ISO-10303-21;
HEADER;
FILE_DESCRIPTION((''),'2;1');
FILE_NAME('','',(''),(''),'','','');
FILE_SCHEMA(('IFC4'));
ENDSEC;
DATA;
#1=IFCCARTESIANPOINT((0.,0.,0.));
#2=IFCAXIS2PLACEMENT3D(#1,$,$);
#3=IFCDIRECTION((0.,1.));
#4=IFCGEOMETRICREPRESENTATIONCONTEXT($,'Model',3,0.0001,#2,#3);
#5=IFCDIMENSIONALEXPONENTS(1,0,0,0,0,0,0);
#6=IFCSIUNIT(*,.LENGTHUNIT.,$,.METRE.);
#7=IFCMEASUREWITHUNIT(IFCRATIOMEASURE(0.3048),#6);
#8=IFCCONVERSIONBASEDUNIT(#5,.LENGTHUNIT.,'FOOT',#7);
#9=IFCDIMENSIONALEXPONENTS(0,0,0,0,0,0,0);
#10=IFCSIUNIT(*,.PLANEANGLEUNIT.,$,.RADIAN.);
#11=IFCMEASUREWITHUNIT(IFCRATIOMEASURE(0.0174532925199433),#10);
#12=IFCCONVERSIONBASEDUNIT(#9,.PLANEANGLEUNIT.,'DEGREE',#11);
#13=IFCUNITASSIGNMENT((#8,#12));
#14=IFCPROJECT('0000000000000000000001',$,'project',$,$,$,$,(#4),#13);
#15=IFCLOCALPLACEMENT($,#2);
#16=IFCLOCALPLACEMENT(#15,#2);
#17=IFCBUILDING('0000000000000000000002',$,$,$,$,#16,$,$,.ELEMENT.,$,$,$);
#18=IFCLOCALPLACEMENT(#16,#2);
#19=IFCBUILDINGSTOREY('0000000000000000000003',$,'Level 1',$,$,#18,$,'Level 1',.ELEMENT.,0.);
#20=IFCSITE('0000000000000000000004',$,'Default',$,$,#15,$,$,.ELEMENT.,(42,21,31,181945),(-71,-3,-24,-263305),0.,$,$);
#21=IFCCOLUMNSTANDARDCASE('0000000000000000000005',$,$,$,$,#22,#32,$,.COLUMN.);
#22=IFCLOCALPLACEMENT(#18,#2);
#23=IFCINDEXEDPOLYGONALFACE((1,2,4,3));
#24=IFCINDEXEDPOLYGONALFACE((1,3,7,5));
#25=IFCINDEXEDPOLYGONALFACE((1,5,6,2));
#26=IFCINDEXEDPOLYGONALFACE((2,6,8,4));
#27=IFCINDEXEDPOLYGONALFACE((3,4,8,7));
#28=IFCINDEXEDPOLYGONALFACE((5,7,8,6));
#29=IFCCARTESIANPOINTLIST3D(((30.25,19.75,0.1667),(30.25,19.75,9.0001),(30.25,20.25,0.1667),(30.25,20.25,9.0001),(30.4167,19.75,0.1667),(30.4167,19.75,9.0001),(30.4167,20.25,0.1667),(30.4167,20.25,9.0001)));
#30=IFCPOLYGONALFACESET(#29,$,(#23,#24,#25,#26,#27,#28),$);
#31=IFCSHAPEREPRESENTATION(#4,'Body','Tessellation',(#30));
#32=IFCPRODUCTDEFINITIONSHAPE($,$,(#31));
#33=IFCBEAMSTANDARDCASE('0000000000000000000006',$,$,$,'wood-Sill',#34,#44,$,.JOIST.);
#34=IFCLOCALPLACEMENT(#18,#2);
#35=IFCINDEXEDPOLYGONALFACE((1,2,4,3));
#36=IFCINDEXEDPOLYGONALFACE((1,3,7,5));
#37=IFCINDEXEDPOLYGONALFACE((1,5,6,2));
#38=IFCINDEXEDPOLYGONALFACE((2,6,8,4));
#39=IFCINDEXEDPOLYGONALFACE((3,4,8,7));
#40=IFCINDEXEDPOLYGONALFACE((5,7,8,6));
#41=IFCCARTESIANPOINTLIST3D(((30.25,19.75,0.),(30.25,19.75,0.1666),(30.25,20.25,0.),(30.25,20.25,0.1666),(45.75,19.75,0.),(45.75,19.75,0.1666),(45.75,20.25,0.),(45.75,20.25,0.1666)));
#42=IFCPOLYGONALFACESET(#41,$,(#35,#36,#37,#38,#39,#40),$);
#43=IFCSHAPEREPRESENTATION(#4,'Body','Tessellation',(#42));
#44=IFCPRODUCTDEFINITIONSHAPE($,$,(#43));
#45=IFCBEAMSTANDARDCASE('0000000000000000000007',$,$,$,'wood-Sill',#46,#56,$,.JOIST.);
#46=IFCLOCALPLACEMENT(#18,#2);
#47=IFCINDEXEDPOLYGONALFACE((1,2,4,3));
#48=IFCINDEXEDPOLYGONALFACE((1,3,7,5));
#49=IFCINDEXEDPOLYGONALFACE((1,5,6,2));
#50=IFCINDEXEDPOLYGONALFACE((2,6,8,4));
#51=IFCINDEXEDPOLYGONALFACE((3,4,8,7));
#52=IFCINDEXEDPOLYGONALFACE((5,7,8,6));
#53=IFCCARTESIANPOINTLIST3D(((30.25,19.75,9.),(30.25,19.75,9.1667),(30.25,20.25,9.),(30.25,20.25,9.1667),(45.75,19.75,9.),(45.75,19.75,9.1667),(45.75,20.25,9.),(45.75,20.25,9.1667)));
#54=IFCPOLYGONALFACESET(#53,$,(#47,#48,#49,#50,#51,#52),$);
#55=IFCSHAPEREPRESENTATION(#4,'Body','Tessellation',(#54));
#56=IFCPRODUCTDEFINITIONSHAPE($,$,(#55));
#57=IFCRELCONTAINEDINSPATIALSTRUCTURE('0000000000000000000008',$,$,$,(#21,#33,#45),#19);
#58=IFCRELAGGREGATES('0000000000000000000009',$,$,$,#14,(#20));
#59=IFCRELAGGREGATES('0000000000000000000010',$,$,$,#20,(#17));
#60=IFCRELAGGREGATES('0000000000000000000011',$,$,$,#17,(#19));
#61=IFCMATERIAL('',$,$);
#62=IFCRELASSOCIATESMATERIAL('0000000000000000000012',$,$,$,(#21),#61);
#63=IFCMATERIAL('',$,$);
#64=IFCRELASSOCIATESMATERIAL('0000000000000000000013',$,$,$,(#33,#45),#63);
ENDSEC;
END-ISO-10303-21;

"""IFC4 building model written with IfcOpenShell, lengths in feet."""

from ifc_helpers import new_model, entity, si_unit, converted_unit, direction, frame, origin, origin_with_axes, place, context, project, spatial, rectangle, extrude, material, element, save


model = new_model("IFC4")

# Units and contexts
model_context = context("Model", 3, precision=0.0001, world=origin(), true_north=direction((0.0, 1.0)))
ifc_project = project(units=[converted_unit("LENGTHUNIT", "FOOT", entity("IfcRatioMeasure", 0.3048), si_unit("LENGTHUNIT", "METRE"), dimensions=[1, 0, 0, 0, 0, 0, 0]), converted_unit("PLANEANGLEUNIT", "DEGREE", entity("IfcRatioMeasure", 0.0174532925199433), si_unit("PLANEANGLEUNIT", "RADIAN"), dimensions=[0, 0, 0, 0, 0, 0, 0])], contexts=[model_context])

# Site, building, storey
site_placement = place(None, origin())
site = spatial("IfcSite", under=ifc_project, at=site_placement, Name="Default", CompositionType="ELEMENT", RefLatitude=(42, 21, 31, 181945), RefLongitude=(-71, -3, -24, -263305), RefElevation=0.0)
building_placement = place(site_placement, origin())
building = spatial("IfcBuilding", under=site, at=building_placement, CompositionType="ELEMENT")
storey_placement = place(building_placement, origin())
storey = spatial("IfcBuildingStorey", under=building, at=storey_placement, Name="Level 1", LongName="Level 1", CompositionType="ELEMENT", Elevation=0.0)

# Column
ifc_material_1 = material(Name="")
placement_1 = place(storey_placement, frame((30.25, 20.0, 0.0)))
for number, where, z_axis, x_axis in (
    (1, (0.0833, 0.0, 0.1667), (0.0, 0.0, 1.0), (1.0, 0.0, 0.0)),
):
    element("IfcColumnStandardCase", number, at=place(placement_1, frame(where, z_axis=z_axis, x_axis=x_axis)), inside=storey, material=ifc_material_1, PredefinedType="COLUMN", context=model_context, shape_type="SweptSolid", body=[
        extrude(rectangle(XDim=0.1667, YDim=0.5), origin(), (0.0, 0.0, 1.0), 8.8334),
    ])

# Beams
ifc_material_2 = material(Name="")
for number, where, z_axis, x_axis in (
    (2, (0.0, 0.0, 0.0833), (1.0, 0.0, 0.0), (0.0, 0.0, 1.0)),
    (3, (0.0, 0.0, 9.0834), (1.0, 0.0, 0.0), (0.0, 0.0, 1.0)),
):
    element("IfcBeamStandardCase", number, at=place(placement_1, frame(where, z_axis=z_axis, x_axis=x_axis)), inside=storey, material=ifc_material_2, ObjectType="wood-Sill", PredefinedType="JOIST", context=model_context, shape_type="SweptSolid", body=[
        extrude(rectangle(XDim=0.1667, YDim=0.5), origin_with_axes(), (0.0, 0.0, 1.0), 15.5),
    ])

save(model, "model.ifc")
